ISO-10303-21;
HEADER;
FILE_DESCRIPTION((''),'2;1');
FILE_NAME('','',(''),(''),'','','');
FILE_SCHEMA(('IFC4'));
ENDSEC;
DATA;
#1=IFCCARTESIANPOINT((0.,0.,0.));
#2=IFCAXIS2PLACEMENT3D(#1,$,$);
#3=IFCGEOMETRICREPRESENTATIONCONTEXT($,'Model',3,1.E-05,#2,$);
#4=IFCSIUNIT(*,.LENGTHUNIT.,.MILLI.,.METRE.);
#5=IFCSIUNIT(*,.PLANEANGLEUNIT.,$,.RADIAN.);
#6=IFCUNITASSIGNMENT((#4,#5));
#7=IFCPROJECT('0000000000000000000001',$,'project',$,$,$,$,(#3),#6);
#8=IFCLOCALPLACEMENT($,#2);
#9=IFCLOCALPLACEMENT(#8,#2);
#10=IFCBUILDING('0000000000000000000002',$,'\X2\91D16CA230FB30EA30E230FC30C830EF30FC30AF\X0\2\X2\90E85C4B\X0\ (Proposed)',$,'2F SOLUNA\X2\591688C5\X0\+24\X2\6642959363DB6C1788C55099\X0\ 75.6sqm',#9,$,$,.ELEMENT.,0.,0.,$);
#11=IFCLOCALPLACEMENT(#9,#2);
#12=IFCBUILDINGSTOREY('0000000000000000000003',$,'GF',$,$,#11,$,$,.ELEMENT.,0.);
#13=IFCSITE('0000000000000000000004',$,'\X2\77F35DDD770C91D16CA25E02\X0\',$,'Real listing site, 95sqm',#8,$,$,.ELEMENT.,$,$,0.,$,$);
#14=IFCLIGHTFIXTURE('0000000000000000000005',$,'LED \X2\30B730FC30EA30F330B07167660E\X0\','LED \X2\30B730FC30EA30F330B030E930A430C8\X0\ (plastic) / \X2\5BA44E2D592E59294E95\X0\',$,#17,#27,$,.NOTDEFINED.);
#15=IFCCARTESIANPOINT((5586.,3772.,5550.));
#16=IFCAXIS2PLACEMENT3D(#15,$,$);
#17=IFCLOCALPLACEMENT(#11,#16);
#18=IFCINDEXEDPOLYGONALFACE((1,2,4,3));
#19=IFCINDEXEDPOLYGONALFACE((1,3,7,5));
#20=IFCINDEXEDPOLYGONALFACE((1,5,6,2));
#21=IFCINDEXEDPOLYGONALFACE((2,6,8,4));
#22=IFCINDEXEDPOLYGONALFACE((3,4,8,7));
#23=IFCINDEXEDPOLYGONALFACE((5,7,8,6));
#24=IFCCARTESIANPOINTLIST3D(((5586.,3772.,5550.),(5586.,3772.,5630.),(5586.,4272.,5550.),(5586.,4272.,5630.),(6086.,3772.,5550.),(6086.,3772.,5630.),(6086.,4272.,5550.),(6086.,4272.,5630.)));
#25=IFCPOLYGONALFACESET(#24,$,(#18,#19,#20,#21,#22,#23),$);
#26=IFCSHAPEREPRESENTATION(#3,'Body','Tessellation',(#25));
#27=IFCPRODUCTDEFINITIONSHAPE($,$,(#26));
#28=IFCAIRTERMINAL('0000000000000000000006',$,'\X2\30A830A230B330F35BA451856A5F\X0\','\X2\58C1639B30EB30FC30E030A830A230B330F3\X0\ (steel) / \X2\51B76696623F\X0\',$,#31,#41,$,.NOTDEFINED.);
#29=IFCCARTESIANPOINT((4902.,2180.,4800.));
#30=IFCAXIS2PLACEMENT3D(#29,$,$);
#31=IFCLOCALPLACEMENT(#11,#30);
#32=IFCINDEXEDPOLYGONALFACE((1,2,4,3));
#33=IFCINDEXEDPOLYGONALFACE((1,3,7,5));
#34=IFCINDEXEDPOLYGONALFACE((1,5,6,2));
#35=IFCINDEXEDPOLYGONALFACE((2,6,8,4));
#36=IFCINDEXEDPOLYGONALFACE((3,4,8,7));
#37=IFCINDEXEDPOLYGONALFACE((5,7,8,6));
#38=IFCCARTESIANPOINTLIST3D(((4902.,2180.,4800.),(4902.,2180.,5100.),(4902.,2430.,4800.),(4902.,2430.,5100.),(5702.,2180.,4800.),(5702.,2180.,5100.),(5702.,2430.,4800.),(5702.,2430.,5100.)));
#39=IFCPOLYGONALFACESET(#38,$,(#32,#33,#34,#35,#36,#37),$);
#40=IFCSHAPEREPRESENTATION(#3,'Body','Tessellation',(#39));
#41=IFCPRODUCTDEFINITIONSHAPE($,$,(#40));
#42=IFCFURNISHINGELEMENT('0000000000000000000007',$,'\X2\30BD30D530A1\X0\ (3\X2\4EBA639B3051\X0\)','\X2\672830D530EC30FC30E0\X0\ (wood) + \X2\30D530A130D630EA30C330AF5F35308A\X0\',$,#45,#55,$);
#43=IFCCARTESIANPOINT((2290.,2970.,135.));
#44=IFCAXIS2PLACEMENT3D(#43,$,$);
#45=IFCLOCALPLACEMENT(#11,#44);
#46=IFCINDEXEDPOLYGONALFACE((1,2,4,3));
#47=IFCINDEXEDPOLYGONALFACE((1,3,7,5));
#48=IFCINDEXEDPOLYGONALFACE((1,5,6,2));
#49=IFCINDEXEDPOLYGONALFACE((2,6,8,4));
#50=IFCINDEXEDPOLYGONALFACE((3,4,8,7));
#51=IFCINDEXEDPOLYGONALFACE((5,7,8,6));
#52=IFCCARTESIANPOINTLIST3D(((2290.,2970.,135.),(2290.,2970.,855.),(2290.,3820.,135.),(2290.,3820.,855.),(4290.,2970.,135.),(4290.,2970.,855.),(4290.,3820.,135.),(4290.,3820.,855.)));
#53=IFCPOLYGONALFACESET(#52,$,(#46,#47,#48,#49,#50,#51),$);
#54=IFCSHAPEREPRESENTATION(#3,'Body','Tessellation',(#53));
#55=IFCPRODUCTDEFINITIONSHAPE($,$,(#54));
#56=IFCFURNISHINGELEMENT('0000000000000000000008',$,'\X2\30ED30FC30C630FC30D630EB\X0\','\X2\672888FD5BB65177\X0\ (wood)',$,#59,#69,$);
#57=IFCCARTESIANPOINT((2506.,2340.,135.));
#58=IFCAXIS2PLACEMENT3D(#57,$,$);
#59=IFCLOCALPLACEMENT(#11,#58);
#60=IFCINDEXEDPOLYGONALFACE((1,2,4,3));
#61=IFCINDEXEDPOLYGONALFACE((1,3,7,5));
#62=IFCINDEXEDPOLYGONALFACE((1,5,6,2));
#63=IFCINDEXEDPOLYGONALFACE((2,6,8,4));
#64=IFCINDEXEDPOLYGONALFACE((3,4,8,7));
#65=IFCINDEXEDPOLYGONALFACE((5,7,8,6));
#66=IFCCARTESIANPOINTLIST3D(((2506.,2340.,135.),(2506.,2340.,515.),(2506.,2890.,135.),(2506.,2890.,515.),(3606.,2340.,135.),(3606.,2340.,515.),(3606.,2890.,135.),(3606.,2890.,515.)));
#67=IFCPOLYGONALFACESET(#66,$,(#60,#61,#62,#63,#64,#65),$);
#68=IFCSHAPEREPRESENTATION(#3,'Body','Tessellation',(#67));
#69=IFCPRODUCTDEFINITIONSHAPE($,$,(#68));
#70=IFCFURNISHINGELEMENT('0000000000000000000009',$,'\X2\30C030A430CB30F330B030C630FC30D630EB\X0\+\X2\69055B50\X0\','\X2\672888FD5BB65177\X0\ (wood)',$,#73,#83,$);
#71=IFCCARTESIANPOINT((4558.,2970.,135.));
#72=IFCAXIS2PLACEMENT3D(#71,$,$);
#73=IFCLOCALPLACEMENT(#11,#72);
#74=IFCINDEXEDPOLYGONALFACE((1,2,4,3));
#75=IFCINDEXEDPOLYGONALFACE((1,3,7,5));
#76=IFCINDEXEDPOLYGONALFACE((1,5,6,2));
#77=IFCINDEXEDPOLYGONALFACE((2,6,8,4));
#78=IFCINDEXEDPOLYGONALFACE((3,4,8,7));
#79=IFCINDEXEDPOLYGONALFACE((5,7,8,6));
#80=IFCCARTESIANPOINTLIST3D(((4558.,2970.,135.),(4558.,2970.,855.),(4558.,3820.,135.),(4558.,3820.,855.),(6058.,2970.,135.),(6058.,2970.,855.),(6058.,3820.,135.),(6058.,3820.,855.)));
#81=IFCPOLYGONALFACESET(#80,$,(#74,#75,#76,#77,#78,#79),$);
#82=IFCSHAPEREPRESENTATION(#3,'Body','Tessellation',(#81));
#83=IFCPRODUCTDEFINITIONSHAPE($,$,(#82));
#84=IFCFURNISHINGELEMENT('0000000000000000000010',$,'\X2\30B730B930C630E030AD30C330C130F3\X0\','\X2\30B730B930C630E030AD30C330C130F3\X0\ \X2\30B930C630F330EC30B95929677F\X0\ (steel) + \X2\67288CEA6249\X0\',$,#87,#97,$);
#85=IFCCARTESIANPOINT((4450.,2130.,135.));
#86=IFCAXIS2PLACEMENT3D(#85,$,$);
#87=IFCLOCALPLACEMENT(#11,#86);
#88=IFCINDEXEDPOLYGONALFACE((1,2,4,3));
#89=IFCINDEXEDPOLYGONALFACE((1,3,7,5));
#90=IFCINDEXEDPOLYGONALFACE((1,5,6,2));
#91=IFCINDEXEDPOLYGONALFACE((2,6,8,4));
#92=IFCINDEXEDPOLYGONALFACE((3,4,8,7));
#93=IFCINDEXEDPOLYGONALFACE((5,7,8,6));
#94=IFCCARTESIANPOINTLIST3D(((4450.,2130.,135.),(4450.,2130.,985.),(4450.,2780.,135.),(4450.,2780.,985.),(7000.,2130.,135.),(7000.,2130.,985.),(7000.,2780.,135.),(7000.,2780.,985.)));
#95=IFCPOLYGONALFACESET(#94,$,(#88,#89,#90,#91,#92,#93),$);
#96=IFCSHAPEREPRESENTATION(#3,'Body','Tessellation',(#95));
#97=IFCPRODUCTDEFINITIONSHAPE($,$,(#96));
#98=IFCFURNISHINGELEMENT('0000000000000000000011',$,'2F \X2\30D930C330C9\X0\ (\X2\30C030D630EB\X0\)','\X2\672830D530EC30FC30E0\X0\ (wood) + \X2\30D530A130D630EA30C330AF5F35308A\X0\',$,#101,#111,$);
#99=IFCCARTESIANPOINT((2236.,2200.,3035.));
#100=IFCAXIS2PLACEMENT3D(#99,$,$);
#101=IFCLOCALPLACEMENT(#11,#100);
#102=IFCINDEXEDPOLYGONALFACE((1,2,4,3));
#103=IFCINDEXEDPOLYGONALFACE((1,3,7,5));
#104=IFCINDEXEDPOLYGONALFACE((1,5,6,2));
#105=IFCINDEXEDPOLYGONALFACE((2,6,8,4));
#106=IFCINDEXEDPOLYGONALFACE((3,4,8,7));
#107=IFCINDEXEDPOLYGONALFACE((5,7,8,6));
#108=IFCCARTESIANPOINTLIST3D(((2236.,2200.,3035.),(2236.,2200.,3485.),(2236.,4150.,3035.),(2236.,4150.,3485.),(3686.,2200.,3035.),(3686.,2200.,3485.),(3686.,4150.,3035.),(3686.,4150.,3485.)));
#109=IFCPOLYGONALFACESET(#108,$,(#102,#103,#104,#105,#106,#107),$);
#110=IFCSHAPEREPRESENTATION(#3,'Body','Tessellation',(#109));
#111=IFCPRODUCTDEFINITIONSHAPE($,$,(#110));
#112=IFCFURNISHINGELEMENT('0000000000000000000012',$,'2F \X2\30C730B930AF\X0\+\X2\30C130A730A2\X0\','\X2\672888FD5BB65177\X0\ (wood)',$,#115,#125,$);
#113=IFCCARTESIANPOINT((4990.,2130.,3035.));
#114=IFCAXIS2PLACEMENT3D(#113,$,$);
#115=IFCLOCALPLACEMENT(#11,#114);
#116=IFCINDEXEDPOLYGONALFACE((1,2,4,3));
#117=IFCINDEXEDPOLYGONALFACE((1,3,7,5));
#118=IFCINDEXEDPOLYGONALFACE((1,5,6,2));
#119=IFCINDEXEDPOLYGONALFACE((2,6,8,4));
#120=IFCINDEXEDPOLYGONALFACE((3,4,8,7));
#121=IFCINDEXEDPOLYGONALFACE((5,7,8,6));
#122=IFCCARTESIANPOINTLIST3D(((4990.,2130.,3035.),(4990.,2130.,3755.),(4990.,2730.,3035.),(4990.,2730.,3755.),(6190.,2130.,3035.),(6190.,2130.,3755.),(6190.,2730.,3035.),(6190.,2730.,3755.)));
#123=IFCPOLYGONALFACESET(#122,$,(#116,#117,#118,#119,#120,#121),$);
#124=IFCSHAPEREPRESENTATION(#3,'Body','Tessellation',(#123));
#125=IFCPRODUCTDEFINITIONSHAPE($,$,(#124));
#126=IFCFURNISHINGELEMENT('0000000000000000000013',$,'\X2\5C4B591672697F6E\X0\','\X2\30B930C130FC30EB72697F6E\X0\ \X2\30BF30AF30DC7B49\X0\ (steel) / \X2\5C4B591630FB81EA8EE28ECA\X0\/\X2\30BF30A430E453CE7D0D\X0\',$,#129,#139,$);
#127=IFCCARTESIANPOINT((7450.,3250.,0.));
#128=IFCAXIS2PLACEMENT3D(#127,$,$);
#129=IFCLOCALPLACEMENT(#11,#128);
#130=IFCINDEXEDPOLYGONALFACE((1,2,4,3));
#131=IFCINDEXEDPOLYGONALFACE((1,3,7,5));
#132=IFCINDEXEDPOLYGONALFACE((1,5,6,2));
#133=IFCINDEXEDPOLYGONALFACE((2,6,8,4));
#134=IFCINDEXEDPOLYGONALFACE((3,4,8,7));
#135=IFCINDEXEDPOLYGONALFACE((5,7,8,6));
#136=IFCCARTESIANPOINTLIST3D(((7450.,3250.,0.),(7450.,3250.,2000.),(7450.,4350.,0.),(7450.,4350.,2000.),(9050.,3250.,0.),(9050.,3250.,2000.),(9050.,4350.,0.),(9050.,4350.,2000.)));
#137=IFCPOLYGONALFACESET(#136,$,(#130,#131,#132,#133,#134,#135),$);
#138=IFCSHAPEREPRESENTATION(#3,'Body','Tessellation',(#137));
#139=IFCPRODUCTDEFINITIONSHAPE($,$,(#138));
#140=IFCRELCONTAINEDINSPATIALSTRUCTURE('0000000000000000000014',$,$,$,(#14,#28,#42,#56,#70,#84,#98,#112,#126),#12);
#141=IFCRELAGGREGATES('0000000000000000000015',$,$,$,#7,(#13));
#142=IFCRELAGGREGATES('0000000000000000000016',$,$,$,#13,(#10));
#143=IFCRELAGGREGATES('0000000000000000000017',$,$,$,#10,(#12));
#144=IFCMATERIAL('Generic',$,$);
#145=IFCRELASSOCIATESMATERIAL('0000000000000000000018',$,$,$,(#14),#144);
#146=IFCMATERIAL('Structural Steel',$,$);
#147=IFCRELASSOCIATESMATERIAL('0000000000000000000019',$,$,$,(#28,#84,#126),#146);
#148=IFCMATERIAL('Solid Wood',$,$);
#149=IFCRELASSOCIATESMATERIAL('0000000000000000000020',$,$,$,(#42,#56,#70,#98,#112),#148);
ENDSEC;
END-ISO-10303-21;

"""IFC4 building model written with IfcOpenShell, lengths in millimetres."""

from ifc_helpers import new_model, si_unit, frame, frame_2d, origin, place, context, project, spatial, rectangle, extrude, material, element, save


model = new_model("IFC4")

# Units and contexts
model_context = context("Model", 3, precision=1e-05, world=origin())
ifc_project = project(units=[si_unit("LENGTHUNIT", "METRE", prefix="MILLI"), si_unit("PLANEANGLEUNIT", "RADIAN")], contexts=[model_context])

# Site, building, storey
site_placement = place(None, origin())
site = spatial("IfcSite", under=ifc_project, at=site_placement, Name="石川県金沢市", ObjectType="Real listing site, 95sqm", CompositionType="ELEMENT", RefElevation=0.0)
building_placement = place(site_placement, origin())
building = spatial("IfcBuilding", under=site, at=building_placement, Name="金沢・リモートワーク2部屋 (Proposed)", ObjectType="2F SOLUNA外装+24時間換気装備 75.6sqm", CompositionType="ELEMENT", ElevationOfRefHeight=0.0, ElevationOfTerrain=0.0)
storey_placement = place(building_placement, origin())
storey = spatial("IfcBuildingStorey", under=building, at=storey_placement, Name="GF", CompositionType="ELEMENT", Elevation=0.0)

# Shared definitions
ifc_material_1 = material(Name="Solid Wood")

# Shared definitions
ifc_material_2 = material(Name="Generic")

# Shared definitions
ifc_material_3 = material(Name="Structural Steel")

# Light fixture
light_fixture_placement = place(storey_placement, frame((5586.0, 3772.0, 5550.0)))
element("IfcLightFixture", 1, at=light_fixture_placement, inside=storey, material=ifc_material_2, Name="LED シーリング照明", Description="LED シーリングライト (plastic) / 室中央天井", PredefinedType="NOTDEFINED", context=model_context, shape_type="SweptSolid", body=[
    extrude(rectangle(XDim=500.0, YDim=500.0, at=frame_2d((250.0, 250.0))), frame((5586.0, 3772.0, 5550.0)), (0.0, 0.0, 1.0), 80.0),
])

# Air terminal
air_terminal_1_placement = place(storey_placement, frame((4902.0, 2180.0, 4800.0)))
element("IfcAirTerminal", 2, at=air_terminal_1_placement, inside=storey, material=ifc_material_3, Name="エアコン室内機", Description="壁掛ルームエアコン (steel) / 冷暖房", PredefinedType="NOTDEFINED", context=model_context, shape_type="SweptSolid", body=[
    extrude(rectangle(XDim=800.0, YDim=250.0, at=frame_2d((400.0, 125.0))), frame((4902.0, 2180.0, 4800.0)), (0.0, 0.0, 1.0), 300.0),
])

# Furnishing elements
furnishing_1_placement = place(storey_placement, frame((2290.0, 2970.0, 135.0)))
element("IfcFurnishingElement", 3, at=furnishing_1_placement, inside=storey, material=ifc_material_1, Name="ソファ (3人掛け)", Description="木フレーム (wood) + ファブリック張り", context=model_context, shape_type="SweptSolid", body=[
    extrude(rectangle(XDim=2000.0, YDim=850.0, at=frame_2d((1000.0, 425.0))), frame((2290.0, 2970.0, 135.0)), (0.0, 0.0, 1.0), 720.0),
])
furnishing_2_placement = place(storey_placement, frame((2506.0, 2340.0, 135.0)))
element("IfcFurnishingElement", 4, at=furnishing_2_placement, inside=storey, material=ifc_material_1, Name="ローテーブル", Description="木製家具 (wood)", context=model_context, shape_type="SweptSolid", body=[
    extrude(rectangle(XDim=1100.0, YDim=550.0, at=frame_2d((550.0, 275.0))), frame((2506.0, 2340.0, 135.0)), (0.0, 0.0, 1.0), 380.0),
])
furnishing_3_placement = place(storey_placement, frame((4558.0, 2970.0, 135.0)))
element("IfcFurnishingElement", 5, at=furnishing_3_placement, inside=storey, material=ifc_material_1, Name="ダイニングテーブル+椅子", Description="木製家具 (wood)", context=model_context, shape_type="SweptSolid", body=[
    extrude(rectangle(XDim=1500.0, YDim=850.0, at=frame_2d((750.0, 425.0))), frame((4558.0, 2970.0, 135.0)), (0.0, 0.0, 1.0), 720.0),
])
furnishing_4_placement = place(storey_placement, frame((4450.0, 2130.0, 135.0)))
element("IfcFurnishingElement", 6, at=furnishing_4_placement, inside=storey, material=ifc_material_3, Name="システムキッチン", Description="システムキッチン ステンレス天板 (steel) + 木質扉", context=model_context, shape_type="SweptSolid", body=[
    extrude(rectangle(XDim=2550.0, YDim=650.0, at=frame_2d((1275.0, 325.0))), frame((4450.0, 2130.0, 135.0)), (0.0, 0.0, 1.0), 850.0),
])
furnishing_5_placement = place(storey_placement, frame((2236.0, 2200.0, 3035.0)))
element("IfcFurnishingElement", 7, at=furnishing_5_placement, inside=storey, material=ifc_material_1, Name="2F ベッド (ダブル)", Description="木フレーム (wood) + ファブリック張り", context=model_context, shape_type="SweptSolid", body=[
    extrude(rectangle(XDim=1450.0, YDim=1950.0, at=frame_2d((725.0, 975.0))), frame((2236.0, 2200.0, 3035.0)), (0.0, 0.0, 1.0), 450.0),
])
furnishing_6_placement = place(storey_placement, frame((4990.0, 2130.0, 3035.0)))
element("IfcFurnishingElement", 8, at=furnishing_6_placement, inside=storey, material=ifc_material_1, Name="2F デスク+チェア", Description="木製家具 (wood)", context=model_context, shape_type="SweptSolid", body=[
    extrude(rectangle(XDim=1200.0, YDim=600.0, at=frame_2d((600.0, 300.0))), frame((4990.0, 2130.0, 3035.0)), (0.0, 0.0, 1.0), 720.0),
])
furnishing_7_placement = place(storey_placement, frame((7450.0, 3250.0, 0.0)))
element("IfcFurnishingElement", 9, at=furnishing_7_placement, inside=storey, material=ifc_material_3, Name="屋外物置", Description="スチール物置 タクボ等 (steel) / 屋外・自転車/タイヤ収納", context=model_context, shape_type="SweptSolid", body=[
    extrude(rectangle(XDim=1600.0, YDim=1100.0, at=frame_2d((800.0, 550.0))), frame((7450.0, 3250.0, 0.0)), (0.0, 0.0, 1.0), 2000.0),
])

save(model, "model.ifc")
